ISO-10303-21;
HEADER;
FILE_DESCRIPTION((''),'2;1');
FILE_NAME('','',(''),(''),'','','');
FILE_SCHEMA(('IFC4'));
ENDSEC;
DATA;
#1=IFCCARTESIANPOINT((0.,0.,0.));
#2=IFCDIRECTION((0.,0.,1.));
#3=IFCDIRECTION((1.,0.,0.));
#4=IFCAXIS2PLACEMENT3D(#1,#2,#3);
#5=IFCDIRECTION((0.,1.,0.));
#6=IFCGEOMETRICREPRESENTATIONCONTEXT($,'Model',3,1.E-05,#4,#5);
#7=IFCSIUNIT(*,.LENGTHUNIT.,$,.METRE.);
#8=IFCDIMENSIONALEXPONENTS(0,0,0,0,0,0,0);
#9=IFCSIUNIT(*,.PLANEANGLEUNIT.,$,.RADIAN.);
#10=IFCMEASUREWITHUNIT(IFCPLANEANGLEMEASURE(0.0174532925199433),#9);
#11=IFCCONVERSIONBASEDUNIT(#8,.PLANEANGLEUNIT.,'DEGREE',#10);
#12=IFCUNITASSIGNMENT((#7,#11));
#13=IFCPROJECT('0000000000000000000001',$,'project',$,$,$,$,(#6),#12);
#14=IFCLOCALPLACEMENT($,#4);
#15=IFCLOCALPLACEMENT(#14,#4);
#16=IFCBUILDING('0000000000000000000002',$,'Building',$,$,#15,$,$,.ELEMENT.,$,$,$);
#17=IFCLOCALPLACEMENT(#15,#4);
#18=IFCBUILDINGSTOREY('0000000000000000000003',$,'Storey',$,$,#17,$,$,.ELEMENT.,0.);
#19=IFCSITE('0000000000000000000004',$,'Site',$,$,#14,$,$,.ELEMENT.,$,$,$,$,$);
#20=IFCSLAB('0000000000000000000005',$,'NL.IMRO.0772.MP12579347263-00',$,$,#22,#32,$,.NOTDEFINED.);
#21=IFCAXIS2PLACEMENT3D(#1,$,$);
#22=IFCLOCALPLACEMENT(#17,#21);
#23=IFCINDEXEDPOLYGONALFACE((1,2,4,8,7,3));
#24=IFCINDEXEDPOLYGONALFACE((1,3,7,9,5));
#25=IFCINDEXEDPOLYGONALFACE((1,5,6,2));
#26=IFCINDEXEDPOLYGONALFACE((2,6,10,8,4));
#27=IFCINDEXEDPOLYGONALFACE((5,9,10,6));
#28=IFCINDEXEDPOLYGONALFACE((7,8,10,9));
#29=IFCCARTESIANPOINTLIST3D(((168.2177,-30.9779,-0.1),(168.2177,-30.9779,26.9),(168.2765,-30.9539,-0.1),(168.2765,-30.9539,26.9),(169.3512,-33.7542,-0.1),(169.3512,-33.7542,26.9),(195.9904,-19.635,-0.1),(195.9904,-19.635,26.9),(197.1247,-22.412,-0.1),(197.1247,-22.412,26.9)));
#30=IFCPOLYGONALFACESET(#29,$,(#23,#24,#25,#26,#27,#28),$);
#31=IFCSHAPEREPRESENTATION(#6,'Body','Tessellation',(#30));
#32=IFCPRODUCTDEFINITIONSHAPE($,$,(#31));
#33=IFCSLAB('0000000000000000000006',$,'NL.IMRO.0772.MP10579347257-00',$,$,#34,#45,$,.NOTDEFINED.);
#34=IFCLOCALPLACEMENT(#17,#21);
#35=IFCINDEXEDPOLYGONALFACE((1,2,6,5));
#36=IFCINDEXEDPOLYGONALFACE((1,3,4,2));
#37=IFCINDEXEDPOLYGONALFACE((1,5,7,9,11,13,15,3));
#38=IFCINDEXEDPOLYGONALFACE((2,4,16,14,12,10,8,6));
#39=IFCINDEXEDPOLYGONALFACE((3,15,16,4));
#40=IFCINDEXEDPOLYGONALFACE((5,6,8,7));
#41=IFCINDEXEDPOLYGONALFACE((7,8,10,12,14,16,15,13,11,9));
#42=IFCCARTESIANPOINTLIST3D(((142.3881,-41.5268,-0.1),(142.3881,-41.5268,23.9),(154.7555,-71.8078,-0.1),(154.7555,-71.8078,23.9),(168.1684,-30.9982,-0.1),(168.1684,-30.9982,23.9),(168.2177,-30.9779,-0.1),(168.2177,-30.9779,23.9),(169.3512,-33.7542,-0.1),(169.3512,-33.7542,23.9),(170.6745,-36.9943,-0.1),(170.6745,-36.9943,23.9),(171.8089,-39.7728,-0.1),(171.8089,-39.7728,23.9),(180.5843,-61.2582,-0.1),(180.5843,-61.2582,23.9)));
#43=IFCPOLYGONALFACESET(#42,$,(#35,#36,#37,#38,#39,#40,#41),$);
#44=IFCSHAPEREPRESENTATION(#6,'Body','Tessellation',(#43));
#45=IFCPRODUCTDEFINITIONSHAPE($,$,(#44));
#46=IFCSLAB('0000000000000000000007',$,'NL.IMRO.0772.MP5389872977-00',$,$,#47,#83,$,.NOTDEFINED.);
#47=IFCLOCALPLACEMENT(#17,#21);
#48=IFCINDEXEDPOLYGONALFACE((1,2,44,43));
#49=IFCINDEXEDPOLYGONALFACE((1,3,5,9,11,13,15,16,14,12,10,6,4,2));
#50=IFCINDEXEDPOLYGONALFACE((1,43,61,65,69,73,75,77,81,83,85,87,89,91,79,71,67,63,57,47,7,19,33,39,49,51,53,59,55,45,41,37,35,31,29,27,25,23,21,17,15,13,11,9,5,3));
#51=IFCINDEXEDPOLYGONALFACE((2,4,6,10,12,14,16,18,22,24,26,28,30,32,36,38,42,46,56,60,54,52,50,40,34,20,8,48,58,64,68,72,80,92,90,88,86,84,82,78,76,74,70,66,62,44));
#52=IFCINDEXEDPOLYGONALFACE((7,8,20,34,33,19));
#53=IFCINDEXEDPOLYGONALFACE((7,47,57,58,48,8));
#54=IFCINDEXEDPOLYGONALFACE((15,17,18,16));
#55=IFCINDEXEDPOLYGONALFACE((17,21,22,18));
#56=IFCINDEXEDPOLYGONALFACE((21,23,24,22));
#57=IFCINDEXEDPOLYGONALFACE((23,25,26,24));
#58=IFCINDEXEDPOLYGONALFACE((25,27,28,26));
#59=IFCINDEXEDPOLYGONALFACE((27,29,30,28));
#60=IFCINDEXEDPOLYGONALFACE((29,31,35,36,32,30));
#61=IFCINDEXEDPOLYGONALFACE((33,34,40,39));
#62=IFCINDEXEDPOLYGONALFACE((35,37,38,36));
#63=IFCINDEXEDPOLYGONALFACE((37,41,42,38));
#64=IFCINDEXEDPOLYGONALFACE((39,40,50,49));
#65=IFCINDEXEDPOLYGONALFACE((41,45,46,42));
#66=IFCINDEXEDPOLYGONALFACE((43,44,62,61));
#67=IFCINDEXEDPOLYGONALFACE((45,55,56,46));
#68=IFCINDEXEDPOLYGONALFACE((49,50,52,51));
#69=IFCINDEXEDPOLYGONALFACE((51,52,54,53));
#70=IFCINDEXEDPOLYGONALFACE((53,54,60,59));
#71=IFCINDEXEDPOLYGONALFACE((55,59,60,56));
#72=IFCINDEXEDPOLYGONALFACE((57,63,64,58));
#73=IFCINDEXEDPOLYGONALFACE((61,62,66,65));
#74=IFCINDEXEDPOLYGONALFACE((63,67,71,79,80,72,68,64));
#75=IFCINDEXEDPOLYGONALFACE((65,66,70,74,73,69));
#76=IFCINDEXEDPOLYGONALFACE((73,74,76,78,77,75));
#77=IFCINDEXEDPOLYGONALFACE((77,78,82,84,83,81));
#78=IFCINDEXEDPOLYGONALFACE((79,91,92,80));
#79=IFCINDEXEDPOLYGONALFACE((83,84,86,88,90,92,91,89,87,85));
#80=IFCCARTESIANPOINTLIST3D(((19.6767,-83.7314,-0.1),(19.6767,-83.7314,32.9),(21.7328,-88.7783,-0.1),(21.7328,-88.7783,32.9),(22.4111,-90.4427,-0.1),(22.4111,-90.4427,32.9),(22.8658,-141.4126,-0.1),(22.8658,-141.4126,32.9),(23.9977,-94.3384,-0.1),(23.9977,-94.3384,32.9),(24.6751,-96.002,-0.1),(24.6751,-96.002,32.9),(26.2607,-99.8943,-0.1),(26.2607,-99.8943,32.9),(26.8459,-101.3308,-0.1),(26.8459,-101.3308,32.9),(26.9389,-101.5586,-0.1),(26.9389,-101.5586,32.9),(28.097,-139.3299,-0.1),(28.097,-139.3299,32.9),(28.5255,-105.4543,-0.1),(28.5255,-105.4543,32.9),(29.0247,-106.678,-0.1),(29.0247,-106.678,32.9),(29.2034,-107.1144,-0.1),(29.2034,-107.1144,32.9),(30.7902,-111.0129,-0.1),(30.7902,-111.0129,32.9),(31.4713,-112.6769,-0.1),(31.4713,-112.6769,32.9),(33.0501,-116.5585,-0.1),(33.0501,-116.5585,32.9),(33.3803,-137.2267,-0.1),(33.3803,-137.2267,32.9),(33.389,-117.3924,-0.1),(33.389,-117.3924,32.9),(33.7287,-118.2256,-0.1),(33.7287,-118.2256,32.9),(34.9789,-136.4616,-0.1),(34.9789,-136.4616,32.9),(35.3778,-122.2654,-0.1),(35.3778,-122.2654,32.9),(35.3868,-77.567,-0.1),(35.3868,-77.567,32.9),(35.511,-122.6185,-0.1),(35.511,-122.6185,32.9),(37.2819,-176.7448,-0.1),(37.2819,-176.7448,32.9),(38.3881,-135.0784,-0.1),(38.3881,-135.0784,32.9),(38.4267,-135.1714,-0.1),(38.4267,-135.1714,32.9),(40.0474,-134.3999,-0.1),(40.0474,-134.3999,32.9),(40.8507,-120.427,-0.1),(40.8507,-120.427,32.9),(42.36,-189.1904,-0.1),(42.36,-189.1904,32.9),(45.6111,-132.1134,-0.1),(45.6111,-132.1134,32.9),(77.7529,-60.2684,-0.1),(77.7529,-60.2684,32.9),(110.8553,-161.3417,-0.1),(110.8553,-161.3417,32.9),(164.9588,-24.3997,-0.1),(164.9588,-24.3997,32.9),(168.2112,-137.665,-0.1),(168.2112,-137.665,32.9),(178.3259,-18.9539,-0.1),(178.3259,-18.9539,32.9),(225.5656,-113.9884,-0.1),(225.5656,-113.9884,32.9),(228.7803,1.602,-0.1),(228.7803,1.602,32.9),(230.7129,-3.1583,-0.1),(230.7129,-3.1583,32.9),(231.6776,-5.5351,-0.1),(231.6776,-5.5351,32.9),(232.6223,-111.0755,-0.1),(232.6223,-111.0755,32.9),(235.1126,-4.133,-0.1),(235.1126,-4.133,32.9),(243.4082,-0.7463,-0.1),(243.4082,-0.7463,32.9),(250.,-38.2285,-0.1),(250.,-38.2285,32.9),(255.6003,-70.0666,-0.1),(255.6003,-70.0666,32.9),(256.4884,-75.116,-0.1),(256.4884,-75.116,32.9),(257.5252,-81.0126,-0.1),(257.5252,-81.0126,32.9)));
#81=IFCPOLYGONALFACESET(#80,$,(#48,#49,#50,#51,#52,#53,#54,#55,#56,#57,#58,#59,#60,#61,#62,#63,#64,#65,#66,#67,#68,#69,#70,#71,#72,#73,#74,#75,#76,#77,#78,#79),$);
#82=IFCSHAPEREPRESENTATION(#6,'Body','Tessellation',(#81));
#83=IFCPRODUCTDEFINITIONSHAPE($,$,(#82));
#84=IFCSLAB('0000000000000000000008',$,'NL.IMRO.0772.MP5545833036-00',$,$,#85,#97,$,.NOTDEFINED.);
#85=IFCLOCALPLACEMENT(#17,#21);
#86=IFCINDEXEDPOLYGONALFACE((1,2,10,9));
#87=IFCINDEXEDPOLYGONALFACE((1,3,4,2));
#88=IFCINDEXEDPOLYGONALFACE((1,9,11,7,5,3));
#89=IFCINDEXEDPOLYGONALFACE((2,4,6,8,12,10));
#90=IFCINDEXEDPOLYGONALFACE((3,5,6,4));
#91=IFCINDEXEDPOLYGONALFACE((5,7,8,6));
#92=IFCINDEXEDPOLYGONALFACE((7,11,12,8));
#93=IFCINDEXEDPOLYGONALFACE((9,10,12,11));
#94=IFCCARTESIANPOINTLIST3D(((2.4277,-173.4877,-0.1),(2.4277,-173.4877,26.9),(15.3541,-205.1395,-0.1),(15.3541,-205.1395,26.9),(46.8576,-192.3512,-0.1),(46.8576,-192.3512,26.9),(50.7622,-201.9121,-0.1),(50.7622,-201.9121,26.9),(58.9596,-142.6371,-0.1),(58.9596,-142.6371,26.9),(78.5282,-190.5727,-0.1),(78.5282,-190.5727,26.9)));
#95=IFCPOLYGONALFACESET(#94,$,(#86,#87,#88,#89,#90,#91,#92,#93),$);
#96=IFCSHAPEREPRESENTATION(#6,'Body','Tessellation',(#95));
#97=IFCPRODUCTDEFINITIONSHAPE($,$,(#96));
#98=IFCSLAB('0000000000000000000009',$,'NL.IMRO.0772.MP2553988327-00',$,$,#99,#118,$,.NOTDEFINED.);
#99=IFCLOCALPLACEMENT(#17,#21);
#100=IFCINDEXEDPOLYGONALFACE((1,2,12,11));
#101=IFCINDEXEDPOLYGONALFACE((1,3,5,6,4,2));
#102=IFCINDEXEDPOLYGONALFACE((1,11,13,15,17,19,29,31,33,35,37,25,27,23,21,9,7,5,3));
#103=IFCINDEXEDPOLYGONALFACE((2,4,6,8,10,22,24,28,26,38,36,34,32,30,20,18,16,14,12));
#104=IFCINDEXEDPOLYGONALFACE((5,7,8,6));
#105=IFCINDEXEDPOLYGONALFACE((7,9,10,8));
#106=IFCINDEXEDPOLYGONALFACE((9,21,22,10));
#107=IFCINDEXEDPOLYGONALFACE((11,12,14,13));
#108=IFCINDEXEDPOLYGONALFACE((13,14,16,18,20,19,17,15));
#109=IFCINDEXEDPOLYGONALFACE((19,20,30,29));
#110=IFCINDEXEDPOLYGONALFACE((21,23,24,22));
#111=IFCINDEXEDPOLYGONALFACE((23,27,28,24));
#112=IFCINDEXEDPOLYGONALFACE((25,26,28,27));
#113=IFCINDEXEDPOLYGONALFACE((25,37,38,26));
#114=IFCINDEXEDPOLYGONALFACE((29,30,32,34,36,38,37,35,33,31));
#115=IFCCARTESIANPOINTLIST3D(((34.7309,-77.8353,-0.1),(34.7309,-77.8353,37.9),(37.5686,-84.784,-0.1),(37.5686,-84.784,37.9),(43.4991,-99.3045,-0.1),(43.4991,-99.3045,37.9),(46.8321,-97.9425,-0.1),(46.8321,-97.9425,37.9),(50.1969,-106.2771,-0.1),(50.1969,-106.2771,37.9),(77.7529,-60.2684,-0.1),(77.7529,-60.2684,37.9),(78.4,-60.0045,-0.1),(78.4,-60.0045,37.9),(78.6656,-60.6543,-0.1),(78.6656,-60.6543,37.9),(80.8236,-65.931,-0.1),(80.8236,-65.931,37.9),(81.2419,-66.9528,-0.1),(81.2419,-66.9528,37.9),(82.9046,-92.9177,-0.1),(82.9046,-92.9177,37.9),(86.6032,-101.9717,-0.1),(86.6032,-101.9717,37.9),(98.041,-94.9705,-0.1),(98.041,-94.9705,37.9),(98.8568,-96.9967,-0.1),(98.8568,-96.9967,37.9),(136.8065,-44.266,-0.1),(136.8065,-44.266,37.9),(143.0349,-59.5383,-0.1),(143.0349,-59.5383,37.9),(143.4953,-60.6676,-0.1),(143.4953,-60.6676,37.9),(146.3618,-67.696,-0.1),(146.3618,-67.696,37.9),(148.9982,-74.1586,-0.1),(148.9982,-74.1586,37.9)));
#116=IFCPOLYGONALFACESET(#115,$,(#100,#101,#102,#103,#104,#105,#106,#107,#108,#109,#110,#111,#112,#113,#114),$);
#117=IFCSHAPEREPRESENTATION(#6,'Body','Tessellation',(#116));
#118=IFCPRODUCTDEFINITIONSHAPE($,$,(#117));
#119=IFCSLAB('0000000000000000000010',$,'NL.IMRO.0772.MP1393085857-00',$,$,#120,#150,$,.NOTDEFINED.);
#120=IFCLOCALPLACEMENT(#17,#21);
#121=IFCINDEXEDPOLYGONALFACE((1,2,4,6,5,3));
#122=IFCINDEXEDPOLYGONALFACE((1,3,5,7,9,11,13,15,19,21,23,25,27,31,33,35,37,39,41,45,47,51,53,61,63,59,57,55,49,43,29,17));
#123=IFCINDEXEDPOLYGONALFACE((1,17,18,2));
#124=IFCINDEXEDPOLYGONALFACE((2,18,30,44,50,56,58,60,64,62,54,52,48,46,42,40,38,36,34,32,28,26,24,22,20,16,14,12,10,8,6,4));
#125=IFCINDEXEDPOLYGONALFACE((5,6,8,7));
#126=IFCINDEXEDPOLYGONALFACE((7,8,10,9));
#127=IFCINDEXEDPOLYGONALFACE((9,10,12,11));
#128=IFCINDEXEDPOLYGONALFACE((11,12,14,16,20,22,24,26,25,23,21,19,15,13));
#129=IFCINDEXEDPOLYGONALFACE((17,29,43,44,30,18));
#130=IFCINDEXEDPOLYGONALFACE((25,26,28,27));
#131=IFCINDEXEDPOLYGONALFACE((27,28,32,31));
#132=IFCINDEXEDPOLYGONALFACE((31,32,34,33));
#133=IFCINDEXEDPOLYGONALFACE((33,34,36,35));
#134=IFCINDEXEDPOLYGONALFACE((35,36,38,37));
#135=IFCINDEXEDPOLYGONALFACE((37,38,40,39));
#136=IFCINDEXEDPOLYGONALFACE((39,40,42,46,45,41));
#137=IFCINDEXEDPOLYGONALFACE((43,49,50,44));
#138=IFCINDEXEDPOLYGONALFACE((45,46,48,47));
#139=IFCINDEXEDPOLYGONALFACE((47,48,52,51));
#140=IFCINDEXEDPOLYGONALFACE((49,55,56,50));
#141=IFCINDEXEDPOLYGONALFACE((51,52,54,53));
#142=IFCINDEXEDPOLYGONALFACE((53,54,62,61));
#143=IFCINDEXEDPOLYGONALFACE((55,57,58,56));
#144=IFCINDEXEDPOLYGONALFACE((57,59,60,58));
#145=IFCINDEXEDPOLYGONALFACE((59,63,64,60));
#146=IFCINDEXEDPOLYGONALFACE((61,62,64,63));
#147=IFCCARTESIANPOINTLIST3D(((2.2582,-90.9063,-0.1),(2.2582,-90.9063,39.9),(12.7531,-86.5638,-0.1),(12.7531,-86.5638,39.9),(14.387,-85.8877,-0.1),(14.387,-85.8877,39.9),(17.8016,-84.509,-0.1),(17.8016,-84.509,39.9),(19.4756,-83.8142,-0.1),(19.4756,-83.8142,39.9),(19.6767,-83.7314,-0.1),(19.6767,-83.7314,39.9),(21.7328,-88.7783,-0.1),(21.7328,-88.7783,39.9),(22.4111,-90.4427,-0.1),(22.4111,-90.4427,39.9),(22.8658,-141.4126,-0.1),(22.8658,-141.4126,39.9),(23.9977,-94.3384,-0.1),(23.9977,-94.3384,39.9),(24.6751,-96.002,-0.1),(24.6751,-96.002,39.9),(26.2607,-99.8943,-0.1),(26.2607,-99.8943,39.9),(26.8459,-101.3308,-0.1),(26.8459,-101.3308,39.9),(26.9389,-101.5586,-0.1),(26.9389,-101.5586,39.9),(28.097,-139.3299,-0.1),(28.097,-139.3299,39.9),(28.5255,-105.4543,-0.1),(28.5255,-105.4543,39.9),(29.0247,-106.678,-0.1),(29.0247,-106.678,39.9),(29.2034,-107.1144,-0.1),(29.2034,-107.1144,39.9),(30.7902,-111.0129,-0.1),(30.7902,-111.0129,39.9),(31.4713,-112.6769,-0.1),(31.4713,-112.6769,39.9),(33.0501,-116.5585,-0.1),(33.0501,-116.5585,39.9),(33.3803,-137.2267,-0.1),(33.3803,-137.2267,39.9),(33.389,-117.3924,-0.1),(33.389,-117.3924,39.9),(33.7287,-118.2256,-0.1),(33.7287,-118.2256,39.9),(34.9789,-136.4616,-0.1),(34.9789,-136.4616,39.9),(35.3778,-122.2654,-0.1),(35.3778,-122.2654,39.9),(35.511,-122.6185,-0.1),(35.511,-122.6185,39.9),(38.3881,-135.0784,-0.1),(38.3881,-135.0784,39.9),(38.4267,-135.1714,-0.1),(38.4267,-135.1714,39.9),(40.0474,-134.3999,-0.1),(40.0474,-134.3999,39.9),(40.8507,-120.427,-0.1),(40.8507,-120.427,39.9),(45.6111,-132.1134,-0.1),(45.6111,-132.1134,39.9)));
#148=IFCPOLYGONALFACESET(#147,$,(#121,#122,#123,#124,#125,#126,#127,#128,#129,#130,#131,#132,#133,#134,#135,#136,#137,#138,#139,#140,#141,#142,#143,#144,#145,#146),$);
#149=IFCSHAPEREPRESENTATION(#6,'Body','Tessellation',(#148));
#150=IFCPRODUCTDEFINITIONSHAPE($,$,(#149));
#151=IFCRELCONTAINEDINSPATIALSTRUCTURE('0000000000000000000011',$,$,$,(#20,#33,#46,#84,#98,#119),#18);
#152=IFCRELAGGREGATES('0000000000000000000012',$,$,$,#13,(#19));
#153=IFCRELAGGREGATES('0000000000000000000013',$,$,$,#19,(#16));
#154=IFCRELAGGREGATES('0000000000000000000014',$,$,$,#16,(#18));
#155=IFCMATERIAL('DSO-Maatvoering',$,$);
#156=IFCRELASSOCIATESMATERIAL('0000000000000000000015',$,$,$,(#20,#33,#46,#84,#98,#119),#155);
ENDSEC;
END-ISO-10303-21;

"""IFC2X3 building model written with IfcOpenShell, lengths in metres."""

from ifc_helpers import new_model, entity, si_unit, converted_unit, direction, frame, origin_with_axes, place, context, project, spatial, polyline, outline, extrude, material, element, save


model = new_model("IFC2X3")

# Units and contexts
model_context = context("Model", 3, precision=1e-05, world=origin_with_axes(), true_north=direction((0.0, 1.0, 0.0)))
ifc_project = project(units=[si_unit("LENGTHUNIT", "METRE"), converted_unit("PLANEANGLEUNIT", "DEGREE", entity("IfcPlaneAngleMeasure", 0.0174532925199433), si_unit("PLANEANGLEUNIT", "RADIAN"), dimensions=[0, 0, 0, 0, 0, 0, 0])], contexts=[model_context])

# Site, building, storey
site_placement = place(None, origin_with_axes())
site = spatial("IfcSite", under=ifc_project, at=site_placement, Name="Site", CompositionType="ELEMENT")
building_placement = place(site_placement, origin_with_axes())
building = spatial("IfcBuilding", under=site, at=building_placement, Name="Building", CompositionType="ELEMENT")
storey_placement = place(building_placement, origin_with_axes())
storey = spatial("IfcBuildingStorey", under=building, at=storey_placement, Name="Storey", CompositionType="ELEMENT", Elevation=0.0)

# Slabs
ifc_material = material(Name="DSO-Maatvoering")
for number, where, z_axis, x_axis, name in (
    (1, (0.0, 0.0, -0.1), (0.0, 0.0, 1.0), (1.0, 0.0, 0.0), "NL.IMRO.0772.MP12579347263-00"),
):
    element("IfcSlab", number, at=place(storey_placement, frame(where, z_axis=z_axis, x_axis=x_axis)), inside=storey, material=ifc_material, Name=name, PredefinedType="NOTDEFINED", context=model_context, shape_type="SweptSolid", body=[
        extrude(outline(polyline([(168.2177, -30.9779), (168.2765, -30.9539), (195.9904, -19.635), (197.1247, -22.412), (169.3512, -33.7542), (168.2177, -30.9779)])), origin_with_axes(), (0.0, 0.0, 1.0), 27.0),
    ])
for number, where, z_axis, x_axis, name in (
    (2, (0.0, 0.0, -0.1), (0.0, 0.0, 1.0), (1.0, 0.0, 0.0), "NL.IMRO.0772.MP10579347257-00"),
):
    element("IfcSlab", number, at=place(storey_placement, frame(where, z_axis=z_axis, x_axis=x_axis)), inside=storey, material=ifc_material, Name=name, PredefinedType="NOTDEFINED", context=model_context, shape_type="SweptSolid", body=[
        extrude(outline(polyline([(168.1684, -30.9982), (168.2177, -30.9779), (169.3512, -33.7542), (170.6745, -36.9943), (171.8089, -39.7728), (180.5843, -61.2582), (154.7555, -71.8078), (142.3881, -41.5268), (168.1684, -30.9982)])), origin_with_axes(), (0.0, 0.0, 1.0), 24.0),
    ])
slab_1_placement = place(storey_placement, frame((0.0, 0.0, -0.1), z_axis=(0.0, 0.0, 1.0), x_axis=(1.0, 0.0, 0.0)))
element("IfcSlab", 3, at=slab_1_placement, inside=storey, material=ifc_material, Name="NL.IMRO.0772.MP5389872977-00", PredefinedType="NOTDEFINED", context=model_context, shape_type="SweptSolid", body=[
    extrude(outline(polyline([(225.5656, -113.9884), (168.2112, -137.665), (110.8553, -161.3417), (42.36, -189.1904), (37.2819, -176.7448), (22.8658, -141.4126), (28.097, -139.3299), (33.3803, -137.2267), (34.9789, -136.4616), (38.3881, -135.0784), (38.4267, -135.1714), (40.0474, -134.3999), (45.6111, -132.1134), (40.8507, -120.427), (35.511, -122.6185), (35.3778, -122.2654), (33.7287, -118.2256), (33.389, -117.3924), (33.0501, -116.5585), (31.4713, -112.6769), (30.7902, -111.0129), (29.2034, -107.1144), (29.0247, -106.678), (28.5255, -105.4543), (26.9389, -101.5586), (26.8459, -101.3308), (26.2607, -99.8943), (24.6751, -96.002), (23.9977, -94.3384), (22.4111, -90.4427), (21.7328, -88.7783), (19.6767, -83.7314), (35.3868, -77.567), (77.7529, -60.2684), (164.9588, -24.3997), (178.3259, -18.9539), (228.7803, 1.602), (230.7129, -3.1583), (231.6776, -5.5351), (235.1126, -4.133), (243.4082, -0.7463), (250.0, -38.2285), (255.6003, -70.0666), (256.4884, -75.116), (257.5252, -81.0126), (232.6223, -111.0755), (225.5656, -113.9884)])), origin_with_axes(), (0.0, 0.0, 1.0), 33.0),
])
for number, where, z_axis, x_axis, name in (
    (4, (0.0, 0.0, -0.1), (0.0, 0.0, 1.0), (1.0, 0.0, 0.0), "NL.IMRO.0772.MP5545833036-00"),
):
    element("IfcSlab", number, at=place(storey_placement, frame(where, z_axis=z_axis, x_axis=x_axis)), inside=storey, material=ifc_material, Name=name, PredefinedType="NOTDEFINED", context=model_context, shape_type="SweptSolid", body=[
        extrude(outline(polyline([(78.5282, -190.5727), (50.7622, -201.9121), (46.8576, -192.3512), (15.3541, -205.1395), (2.4277, -173.4877), (58.9596, -142.6371), (78.5282, -190.5727)])), origin_with_axes(), (0.0, 0.0, 1.0), 27.0),
    ])
for number, where, z_axis, x_axis, name in (
    (5, (0.0, 0.0, -0.1), (0.0, 0.0, 1.0), (1.0, 0.0, 0.0), "NL.IMRO.0772.MP2553988327-00"),
):
    element("IfcSlab", number, at=place(storey_placement, frame(where, z_axis=z_axis, x_axis=x_axis)), inside=storey, material=ifc_material, Name=name, PredefinedType="NOTDEFINED", context=model_context, shape_type="SweptSolid", body=[
        extrude(outline(polyline([(78.6656, -60.6543), (80.8236, -65.931), (81.2419, -66.9528), (136.8065, -44.266), (143.0349, -59.5383), (143.4953, -60.6676), (146.3618, -67.696), (148.9982, -74.1586), (98.041, -94.9705), (98.8568, -96.9967), (86.6032, -101.9717), (82.9046, -92.9177), (50.1969, -106.2771), (46.8321, -97.9425), (43.4991, -99.3045), (37.5686, -84.784), (34.7309, -77.8353), (77.7529, -60.2684), (78.4, -60.0045), (78.6656, -60.6543)])), origin_with_axes(), (0.0, 0.0, 1.0), 38.0),
    ])
slab_2_placement = place(storey_placement, frame((0.0, 0.0, -0.1), z_axis=(0.0, 0.0, 1.0), x_axis=(1.0, 0.0, 0.0)))
element("IfcSlab", 6, at=slab_2_placement, inside=storey, material=ifc_material, Name="NL.IMRO.0772.MP1393085857-00", PredefinedType="NOTDEFINED", context=model_context, shape_type="SweptSolid", body=[
    extrude(outline(polyline([(22.8658, -141.4126), (2.2582, -90.9063), (12.7531, -86.5638), (14.387, -85.8877), (17.8016, -84.509), (19.4756, -83.8142), (19.6767, -83.7314), (21.7328, -88.7783), (22.4111, -90.4427), (23.9977, -94.3384), (24.6751, -96.002), (26.2607, -99.8943), (26.8459, -101.3308), (26.9389, -101.5586), (28.5255, -105.4543), (29.0247, -106.678), (29.2034, -107.1144), (30.7902, -111.0129), (31.4713, -112.6769), (33.0501, -116.5585), (33.389, -117.3924), (33.7287, -118.2256), (35.3778, -122.2654), (35.511, -122.6185), (40.8507, -120.427), (45.6111, -132.1134), (40.0474, -134.3999), (38.4267, -135.1714), (38.3881, -135.0784), (34.9789, -136.4616), (33.3803, -137.2267), (28.097, -139.3299), (22.8658, -141.4126)])), origin_with_axes(), (0.0, 0.0, 1.0), 40.0),
])

save(model, "model.ifc")
